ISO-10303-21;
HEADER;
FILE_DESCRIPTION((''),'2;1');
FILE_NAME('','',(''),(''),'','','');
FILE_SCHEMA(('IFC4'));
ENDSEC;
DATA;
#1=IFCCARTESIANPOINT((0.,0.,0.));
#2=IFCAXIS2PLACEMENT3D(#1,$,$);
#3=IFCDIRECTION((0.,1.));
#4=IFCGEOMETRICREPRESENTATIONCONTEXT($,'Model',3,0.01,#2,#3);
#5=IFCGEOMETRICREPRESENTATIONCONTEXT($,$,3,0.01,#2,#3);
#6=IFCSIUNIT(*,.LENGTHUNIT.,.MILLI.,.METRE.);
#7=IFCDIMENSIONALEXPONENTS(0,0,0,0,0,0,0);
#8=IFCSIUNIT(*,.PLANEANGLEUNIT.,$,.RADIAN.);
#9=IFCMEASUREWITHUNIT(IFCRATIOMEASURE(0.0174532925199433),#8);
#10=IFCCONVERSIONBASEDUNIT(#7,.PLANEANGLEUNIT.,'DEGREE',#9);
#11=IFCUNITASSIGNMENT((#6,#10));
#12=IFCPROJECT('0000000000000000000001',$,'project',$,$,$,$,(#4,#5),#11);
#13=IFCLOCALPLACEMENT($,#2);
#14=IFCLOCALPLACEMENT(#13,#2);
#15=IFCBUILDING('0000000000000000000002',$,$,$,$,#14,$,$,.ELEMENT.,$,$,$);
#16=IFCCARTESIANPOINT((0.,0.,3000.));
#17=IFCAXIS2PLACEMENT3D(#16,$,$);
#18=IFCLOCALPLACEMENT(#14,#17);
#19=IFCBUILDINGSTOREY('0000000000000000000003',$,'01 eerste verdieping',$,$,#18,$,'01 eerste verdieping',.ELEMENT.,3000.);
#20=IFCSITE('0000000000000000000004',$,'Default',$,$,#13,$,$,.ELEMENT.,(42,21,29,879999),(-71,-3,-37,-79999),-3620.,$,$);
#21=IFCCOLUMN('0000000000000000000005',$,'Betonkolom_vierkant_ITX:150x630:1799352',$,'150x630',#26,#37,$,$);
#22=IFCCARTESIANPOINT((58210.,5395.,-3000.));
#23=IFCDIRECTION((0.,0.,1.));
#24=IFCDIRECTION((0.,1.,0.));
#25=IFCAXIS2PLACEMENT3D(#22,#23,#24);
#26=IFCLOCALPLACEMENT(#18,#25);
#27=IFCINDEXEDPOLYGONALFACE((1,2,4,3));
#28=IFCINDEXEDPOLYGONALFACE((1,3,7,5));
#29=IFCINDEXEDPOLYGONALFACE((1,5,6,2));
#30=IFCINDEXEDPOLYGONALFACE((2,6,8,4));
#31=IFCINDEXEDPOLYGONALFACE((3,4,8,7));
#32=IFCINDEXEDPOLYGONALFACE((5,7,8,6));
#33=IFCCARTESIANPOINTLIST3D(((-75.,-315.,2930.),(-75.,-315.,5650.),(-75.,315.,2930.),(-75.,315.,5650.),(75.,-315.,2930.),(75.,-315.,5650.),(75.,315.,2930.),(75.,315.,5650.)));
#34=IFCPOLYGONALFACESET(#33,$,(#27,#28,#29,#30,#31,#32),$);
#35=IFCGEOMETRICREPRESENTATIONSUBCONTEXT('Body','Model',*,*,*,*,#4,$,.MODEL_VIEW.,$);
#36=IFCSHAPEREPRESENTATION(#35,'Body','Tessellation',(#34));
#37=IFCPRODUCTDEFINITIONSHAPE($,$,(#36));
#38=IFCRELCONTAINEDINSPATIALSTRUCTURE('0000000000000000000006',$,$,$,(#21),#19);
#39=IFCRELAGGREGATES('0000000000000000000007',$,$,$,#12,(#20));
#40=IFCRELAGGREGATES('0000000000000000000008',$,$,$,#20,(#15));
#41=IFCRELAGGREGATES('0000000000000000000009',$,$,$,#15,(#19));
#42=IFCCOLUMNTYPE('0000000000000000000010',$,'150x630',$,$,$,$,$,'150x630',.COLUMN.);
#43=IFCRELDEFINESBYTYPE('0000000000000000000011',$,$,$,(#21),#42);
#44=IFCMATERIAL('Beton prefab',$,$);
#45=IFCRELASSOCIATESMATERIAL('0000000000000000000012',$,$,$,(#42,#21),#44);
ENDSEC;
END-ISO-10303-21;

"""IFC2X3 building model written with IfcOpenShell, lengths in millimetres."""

from ifc_helpers import new_model, entity, si_unit, converted_unit, direction, frame, origin, origin_2d_with_axis, place, context, subcontext, project, spatial, rectangle, extrude, source, transform, mapped, material, type_object, type_shapes, element, save


model = new_model("IFC2X3")

# Units and contexts
model_context = context("Model", 3, precision=0.01, world=origin(), true_north=direction((0.0, 1.0)))
context_of_model = context(None, 3, precision=0.01, world=origin(), true_north=direction((0.0, 1.0)))
body_context = subcontext(model_context, "Body", "Model", "MODEL_VIEW")
ifc_project = project(units=[si_unit("LENGTHUNIT", "METRE", prefix="MILLI"), converted_unit("PLANEANGLEUNIT", "DEGREE", entity("IfcRatioMeasure", 0.0174532925199433), si_unit("PLANEANGLEUNIT", "RADIAN"), dimensions=[0, 0, 0, 0, 0, 0, 0])], contexts=[model_context, context_of_model])

# Site, building, storey
site_placement = place(None, origin())
site = spatial("IfcSite", under=ifc_project, at=site_placement, Name="Default", CompositionType="ELEMENT", RefLatitude=(42, 21, 29, 879999), RefLongitude=(-71, -3, -37, -79999), RefElevation=-3620.0)
building_placement = place(site_placement, origin())
building = spatial("IfcBuilding", under=site, at=building_placement, CompositionType="ELEMENT")
storey_placement = place(building_placement, frame((0.0, 0.0, 3000.0)))
storey = spatial("IfcBuildingStorey", under=building, at=storey_placement, Name="01 eerste verdieping", LongName="01 eerste verdieping", CompositionType="ELEMENT", Elevation=3000.0)

# Column
ifc_material_1 = material(Name="Beton prefab")
column_type = type_object("IfcColumnType", Name="150x630", ElementType="150x630", PredefinedType="COLUMN", material=ifc_material_1)
shared_shape = source(origin(), body_context, "Body", "SweptSolid", [
    extrude(rectangle(XDim=630.0, YDim=150.0, at=origin_2d_with_axis()), frame((0.0, 0.0, 2930.0), z_axis=(0.0, 0.0, 1.0), x_axis=(0.0, -1.0, 0.0)), (0.0, 0.0, 1.0), 2720.0),
])
type_shapes(column_type, [shared_shape])
column_placement = place(storey_placement, frame((58210.0, 5395.0, -3000.0), z_axis=(0.0, 0.0, 1.0), x_axis=(0.0, 1.0, 0.0)))
element("IfcColumn", 1, at=column_placement, inside=storey, type_object=column_type, material=ifc_material_1, Name="Betonkolom_vierkant_ITX:150x630:1799352", ObjectType="150x630", context=body_context, shape_type="MappedRepresentation", body=[
    mapped(shared_shape, transform((0.0, 0.0, 0.0), scale=1.0)),
])

save(model, "model.ifc")
